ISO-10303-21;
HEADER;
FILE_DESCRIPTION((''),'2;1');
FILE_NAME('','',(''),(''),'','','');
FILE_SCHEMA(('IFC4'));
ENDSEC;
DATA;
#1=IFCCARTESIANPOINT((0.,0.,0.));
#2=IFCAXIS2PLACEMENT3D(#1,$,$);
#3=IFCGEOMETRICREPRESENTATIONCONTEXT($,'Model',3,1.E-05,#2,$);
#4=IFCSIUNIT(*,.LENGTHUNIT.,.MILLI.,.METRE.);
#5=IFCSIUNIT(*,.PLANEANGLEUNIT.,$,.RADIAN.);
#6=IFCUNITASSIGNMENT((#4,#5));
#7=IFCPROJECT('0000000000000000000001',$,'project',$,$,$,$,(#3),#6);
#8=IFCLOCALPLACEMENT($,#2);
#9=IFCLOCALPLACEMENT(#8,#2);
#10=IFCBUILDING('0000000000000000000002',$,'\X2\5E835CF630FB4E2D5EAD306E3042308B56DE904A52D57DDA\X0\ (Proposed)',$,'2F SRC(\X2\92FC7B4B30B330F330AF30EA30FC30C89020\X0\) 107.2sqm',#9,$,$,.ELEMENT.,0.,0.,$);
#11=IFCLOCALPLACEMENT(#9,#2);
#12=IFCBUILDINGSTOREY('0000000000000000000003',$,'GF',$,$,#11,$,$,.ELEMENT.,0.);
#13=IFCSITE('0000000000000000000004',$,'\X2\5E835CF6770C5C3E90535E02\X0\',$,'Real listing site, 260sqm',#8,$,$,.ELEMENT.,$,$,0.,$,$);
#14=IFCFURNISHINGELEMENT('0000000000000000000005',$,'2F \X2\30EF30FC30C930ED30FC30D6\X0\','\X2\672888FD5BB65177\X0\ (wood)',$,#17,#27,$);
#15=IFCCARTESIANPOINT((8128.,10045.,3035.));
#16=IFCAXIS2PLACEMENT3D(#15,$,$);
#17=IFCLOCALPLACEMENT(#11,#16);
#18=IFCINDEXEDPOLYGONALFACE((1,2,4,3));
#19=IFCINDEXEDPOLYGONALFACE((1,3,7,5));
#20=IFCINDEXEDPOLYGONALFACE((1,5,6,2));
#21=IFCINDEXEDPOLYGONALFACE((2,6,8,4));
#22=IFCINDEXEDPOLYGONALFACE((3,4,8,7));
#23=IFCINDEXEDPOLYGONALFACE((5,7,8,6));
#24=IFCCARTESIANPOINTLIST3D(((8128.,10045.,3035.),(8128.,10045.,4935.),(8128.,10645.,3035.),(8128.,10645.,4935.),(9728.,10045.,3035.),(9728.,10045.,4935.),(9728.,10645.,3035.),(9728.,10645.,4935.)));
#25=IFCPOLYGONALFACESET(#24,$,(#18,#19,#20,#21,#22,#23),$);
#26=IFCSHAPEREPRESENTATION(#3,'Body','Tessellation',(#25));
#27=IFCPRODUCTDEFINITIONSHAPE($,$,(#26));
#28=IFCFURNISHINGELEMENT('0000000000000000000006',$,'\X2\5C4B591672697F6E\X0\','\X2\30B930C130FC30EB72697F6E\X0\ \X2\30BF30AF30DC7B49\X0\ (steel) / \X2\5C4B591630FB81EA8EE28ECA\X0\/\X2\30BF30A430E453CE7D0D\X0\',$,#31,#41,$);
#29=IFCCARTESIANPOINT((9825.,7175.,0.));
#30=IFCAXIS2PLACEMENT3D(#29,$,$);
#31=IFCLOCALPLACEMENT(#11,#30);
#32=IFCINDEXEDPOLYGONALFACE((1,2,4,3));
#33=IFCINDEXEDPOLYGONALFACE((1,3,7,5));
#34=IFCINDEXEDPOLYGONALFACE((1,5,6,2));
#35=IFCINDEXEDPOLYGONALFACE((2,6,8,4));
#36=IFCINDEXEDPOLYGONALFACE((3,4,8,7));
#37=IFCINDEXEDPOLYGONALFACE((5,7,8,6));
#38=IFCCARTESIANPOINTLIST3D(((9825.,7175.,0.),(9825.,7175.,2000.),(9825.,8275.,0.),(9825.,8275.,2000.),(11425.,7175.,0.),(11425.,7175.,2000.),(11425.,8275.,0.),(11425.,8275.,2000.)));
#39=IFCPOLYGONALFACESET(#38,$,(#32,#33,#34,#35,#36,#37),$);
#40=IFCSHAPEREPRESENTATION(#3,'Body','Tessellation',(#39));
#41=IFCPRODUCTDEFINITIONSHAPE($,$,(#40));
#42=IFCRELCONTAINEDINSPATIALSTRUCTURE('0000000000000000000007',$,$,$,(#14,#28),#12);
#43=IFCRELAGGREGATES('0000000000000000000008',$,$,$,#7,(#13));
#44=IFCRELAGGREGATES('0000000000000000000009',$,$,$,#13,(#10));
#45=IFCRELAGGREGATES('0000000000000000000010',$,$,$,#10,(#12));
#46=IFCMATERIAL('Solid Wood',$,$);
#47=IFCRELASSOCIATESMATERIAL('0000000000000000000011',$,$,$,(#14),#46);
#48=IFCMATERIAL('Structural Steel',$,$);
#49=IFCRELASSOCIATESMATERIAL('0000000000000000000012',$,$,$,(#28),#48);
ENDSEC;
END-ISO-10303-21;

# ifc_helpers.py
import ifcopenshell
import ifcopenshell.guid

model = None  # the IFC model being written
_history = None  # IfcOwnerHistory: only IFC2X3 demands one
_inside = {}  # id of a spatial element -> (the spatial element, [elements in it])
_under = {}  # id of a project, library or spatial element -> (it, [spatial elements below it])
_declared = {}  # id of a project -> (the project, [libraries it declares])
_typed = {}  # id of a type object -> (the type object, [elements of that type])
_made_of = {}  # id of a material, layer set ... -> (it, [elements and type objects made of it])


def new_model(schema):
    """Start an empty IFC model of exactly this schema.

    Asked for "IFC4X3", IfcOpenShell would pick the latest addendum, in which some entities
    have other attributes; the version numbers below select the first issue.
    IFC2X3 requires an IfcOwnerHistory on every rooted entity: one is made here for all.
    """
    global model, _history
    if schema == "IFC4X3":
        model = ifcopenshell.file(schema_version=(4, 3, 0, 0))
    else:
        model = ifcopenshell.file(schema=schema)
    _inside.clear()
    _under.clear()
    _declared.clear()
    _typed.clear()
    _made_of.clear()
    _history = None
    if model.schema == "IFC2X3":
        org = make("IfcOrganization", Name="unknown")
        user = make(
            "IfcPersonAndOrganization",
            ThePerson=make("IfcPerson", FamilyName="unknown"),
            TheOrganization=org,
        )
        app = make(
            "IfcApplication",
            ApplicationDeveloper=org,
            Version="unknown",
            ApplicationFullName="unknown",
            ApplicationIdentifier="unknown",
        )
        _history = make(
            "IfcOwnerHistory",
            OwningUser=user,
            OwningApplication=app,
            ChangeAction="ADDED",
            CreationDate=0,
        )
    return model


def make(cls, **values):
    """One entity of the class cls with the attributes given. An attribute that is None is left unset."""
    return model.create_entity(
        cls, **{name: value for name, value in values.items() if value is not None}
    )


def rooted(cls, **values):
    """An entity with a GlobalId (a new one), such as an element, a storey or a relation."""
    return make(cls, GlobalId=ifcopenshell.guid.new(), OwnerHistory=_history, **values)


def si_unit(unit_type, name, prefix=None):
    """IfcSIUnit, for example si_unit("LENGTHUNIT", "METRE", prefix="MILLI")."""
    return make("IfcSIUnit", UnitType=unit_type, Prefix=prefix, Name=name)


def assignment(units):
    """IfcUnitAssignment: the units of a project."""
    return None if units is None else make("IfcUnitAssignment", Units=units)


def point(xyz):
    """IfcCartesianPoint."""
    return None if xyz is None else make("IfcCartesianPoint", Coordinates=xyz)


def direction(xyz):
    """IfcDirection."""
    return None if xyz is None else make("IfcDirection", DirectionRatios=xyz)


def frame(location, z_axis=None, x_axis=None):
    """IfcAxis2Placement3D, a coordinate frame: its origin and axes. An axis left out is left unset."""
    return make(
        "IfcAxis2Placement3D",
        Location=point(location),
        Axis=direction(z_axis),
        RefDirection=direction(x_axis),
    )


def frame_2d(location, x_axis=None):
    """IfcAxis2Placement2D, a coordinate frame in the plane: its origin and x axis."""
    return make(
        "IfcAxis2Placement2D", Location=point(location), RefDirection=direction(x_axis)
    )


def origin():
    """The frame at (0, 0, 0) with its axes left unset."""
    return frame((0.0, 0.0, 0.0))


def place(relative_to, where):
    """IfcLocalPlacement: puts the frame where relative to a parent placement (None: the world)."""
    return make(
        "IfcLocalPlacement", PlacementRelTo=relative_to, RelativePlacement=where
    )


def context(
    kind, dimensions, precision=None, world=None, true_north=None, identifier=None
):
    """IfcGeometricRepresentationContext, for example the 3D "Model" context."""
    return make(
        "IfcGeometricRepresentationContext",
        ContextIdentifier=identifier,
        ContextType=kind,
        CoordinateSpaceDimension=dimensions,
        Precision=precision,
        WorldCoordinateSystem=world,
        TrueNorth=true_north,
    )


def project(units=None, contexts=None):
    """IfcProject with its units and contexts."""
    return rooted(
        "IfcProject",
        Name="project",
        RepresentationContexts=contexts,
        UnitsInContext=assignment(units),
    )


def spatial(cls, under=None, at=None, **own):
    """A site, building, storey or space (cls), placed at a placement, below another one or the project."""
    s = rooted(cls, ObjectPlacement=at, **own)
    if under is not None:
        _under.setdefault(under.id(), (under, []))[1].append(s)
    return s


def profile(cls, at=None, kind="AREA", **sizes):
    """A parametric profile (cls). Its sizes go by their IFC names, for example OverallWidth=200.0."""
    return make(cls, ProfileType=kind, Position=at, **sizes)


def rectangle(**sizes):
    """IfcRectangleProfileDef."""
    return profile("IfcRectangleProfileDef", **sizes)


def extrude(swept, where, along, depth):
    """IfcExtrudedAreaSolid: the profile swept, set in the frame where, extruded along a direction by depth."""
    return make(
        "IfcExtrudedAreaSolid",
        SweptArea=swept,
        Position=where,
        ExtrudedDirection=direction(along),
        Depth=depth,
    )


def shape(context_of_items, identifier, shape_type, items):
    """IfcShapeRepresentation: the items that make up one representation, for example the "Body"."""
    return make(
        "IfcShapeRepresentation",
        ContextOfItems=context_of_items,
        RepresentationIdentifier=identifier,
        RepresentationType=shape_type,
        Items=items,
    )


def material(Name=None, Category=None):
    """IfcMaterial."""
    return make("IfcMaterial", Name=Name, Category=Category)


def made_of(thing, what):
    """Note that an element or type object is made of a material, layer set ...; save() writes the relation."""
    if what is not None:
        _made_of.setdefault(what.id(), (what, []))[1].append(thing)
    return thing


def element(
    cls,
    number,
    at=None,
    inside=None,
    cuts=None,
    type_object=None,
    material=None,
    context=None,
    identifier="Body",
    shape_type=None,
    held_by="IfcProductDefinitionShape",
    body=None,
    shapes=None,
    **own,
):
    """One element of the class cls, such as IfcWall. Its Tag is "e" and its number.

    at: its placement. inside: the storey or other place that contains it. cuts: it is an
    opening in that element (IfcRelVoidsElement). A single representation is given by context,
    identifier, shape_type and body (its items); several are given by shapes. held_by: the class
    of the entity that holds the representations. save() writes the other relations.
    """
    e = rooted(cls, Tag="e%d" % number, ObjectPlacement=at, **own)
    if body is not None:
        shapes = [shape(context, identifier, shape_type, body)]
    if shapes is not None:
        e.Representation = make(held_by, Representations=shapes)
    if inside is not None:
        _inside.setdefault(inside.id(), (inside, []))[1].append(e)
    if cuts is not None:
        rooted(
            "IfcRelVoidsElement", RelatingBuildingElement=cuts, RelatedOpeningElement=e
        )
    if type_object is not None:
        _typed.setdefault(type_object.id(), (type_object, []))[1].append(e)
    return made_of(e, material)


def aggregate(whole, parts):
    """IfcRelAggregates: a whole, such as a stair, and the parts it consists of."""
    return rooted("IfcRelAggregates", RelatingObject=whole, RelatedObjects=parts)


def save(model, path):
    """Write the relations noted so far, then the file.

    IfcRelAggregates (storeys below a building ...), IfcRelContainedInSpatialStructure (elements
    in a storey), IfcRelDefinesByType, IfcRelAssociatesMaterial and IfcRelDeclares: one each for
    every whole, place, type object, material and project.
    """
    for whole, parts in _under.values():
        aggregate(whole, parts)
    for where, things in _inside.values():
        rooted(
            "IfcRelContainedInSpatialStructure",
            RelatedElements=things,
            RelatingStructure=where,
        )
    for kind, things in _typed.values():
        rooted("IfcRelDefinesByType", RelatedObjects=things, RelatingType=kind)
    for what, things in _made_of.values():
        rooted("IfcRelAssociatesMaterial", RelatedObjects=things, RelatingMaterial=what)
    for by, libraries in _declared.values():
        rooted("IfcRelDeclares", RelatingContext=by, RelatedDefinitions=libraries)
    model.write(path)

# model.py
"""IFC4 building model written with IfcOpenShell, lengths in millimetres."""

from ifc_helpers import new_model, si_unit, frame, frame_2d, origin, place, context, project, spatial, rectangle, extrude, material, element, save


model = new_model("IFC4")

# Units and contexts
model_context = context("Model", 3, precision=1e-05, world=origin())
ifc_project = project(units=[si_unit("LENGTHUNIT", "METRE", prefix="MILLI"), si_unit("PLANEANGLEUNIT", "RADIAN")], contexts=[model_context])

# Site, building, storey
site_placement = place(None, origin())
site = spatial("IfcSite", under=ifc_project, at=site_placement, Name="広島県尾道市", ObjectType="Real listing site, 260sqm", CompositionType="ELEMENT", RefElevation=0.0)
building_placement = place(site_placement, origin())
building = spatial("IfcBuilding", under=site, at=building_placement, Name="広島・中庭のある回遊動線 (Proposed)", ObjectType="2F SRC(鋼筋コンクリート造) 107.2sqm", CompositionType="ELEMENT", ElevationOfRefHeight=0.0, ElevationOfTerrain=0.0)
storey_placement = place(building_placement, origin())
storey = spatial("IfcBuildingStorey", under=building, at=storey_placement, Name="GF", CompositionType="ELEMENT", Elevation=0.0)

# Shared definitions
ifc_material_1 = material(Name="Solid Wood")

# Shared definitions
ifc_material_2 = material(Name="Structural Steel")

# Furnishing elements
furnishing_1_placement = place(storey_placement, frame((8128.0, 10045.0, 3035.0)))
element("IfcFurnishingElement", 1, at=furnishing_1_placement, inside=storey, material=ifc_material_1, Name="2F ワードローブ", Description="木製家具 (wood)", context=model_context, shape_type="SweptSolid", body=[
    extrude(rectangle(XDim=1600.0, YDim=600.0, at=frame_2d((800.0, 300.0))), frame((8128.0, 10045.0, 3035.0)), (0.0, 0.0, 1.0), 1900.0),
])
furnishing_2_placement = place(storey_placement, frame((9825.0, 7175.0, 0.0)))
element("IfcFurnishingElement", 2, at=furnishing_2_placement, inside=storey, material=ifc_material_2, Name="屋外物置", Description="スチール物置 タクボ等 (steel) / 屋外・自転車/タイヤ収納", context=model_context, shape_type="SweptSolid", body=[
    extrude(rectangle(XDim=1600.0, YDim=1100.0, at=frame_2d((800.0, 550.0))), frame((9825.0, 7175.0, 0.0)), (0.0, 0.0, 1.0), 2000.0),
])

save(model, "model.ifc")
